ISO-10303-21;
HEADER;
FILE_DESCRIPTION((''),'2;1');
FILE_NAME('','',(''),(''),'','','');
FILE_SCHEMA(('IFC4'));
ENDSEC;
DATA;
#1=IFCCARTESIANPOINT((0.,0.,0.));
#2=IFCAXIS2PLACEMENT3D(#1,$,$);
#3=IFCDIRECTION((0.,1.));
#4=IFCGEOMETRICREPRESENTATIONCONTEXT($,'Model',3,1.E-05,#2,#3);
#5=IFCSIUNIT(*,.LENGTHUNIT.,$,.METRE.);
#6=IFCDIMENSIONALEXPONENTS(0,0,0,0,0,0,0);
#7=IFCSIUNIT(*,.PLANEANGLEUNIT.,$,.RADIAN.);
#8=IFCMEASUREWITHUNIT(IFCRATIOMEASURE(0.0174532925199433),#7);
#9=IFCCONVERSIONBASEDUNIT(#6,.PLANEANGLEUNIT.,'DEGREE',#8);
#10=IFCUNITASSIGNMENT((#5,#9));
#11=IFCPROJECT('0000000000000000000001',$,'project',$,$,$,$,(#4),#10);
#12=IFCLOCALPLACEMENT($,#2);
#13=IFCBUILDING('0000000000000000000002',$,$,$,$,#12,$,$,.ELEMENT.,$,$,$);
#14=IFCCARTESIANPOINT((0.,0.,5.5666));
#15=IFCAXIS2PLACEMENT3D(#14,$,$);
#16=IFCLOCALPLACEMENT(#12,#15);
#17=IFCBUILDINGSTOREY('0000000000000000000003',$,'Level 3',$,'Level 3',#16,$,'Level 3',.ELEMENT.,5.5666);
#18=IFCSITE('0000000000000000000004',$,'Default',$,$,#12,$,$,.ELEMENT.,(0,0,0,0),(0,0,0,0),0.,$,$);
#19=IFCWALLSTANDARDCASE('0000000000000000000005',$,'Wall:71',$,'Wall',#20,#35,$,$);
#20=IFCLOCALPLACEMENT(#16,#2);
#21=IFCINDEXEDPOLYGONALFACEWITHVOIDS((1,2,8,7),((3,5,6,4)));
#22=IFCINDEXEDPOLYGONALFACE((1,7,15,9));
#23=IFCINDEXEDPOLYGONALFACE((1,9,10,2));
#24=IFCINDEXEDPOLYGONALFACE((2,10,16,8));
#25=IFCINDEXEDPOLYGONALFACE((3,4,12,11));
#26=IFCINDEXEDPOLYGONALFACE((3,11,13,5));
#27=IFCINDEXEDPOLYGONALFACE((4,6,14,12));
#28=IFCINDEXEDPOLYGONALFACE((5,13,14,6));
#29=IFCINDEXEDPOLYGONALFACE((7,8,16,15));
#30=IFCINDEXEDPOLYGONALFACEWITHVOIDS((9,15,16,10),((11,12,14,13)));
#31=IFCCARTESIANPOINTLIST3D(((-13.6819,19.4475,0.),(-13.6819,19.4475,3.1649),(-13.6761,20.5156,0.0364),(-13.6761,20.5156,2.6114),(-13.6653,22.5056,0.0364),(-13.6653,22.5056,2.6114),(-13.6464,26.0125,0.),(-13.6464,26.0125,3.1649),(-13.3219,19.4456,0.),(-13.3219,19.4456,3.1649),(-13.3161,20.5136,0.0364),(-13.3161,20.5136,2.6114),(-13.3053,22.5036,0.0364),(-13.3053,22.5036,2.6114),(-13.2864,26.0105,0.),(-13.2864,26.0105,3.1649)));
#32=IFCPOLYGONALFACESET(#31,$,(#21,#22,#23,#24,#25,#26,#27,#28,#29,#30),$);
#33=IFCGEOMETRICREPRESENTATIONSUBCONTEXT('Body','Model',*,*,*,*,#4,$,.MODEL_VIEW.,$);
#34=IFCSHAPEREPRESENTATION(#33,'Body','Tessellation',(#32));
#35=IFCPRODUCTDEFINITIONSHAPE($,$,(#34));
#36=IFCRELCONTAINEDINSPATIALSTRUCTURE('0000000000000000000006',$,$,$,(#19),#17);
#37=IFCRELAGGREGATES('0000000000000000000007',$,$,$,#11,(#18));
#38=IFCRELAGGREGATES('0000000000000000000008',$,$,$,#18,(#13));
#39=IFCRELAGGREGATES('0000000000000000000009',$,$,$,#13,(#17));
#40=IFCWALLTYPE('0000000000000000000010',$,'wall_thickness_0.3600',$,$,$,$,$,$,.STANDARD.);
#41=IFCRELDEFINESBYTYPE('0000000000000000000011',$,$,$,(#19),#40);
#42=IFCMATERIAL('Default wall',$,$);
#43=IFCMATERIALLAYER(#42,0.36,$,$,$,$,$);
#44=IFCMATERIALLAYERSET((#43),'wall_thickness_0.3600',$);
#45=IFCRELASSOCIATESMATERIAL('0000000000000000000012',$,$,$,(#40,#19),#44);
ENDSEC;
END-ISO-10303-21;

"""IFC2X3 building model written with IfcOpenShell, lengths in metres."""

from ifc_helpers import new_model, entity, si_unit, converted_unit, direction, frame, frame_2d, origin, place, context, subcontext, project, spatial, polyline, rectangle, outline, extrude, material, layer, layer_set, layer_usage, type_object, element, save


model = new_model("IFC2X3")

# Units and contexts
model_context = context("Model", 3, precision=1e-05, world=origin(), true_north=direction((0.0, 1.0)))
body_context = subcontext(model_context, "Body", "Model", "MODEL_VIEW")
ifc_project = project(units=[si_unit("LENGTHUNIT", "METRE"), converted_unit("PLANEANGLEUNIT", "DEGREE", entity("IfcRatioMeasure", 0.0174532925199433), si_unit("PLANEANGLEUNIT", "RADIAN"), dimensions=[0, 0, 0, 0, 0, 0, 0])], contexts=[model_context])

# Site, building, storey
placement_1 = place(None, origin())
site = spatial("IfcSite", under=ifc_project, at=placement_1, Name="Default", CompositionType="ELEMENT", RefLatitude=(0, 0, 0, 0), RefLongitude=(0, 0, 0, 0), RefElevation=0.0)
building = spatial("IfcBuilding", under=site, at=placement_1, CompositionType="ELEMENT")
storey_placement = place(placement_1, frame((0.0, 0.0, 5.5666)))
storey = spatial("IfcBuildingStorey", under=building, at=storey_placement, Name="Level 3", ObjectType="Level 3", LongName="Level 3", CompositionType="ELEMENT", Elevation=5.5666)

# Shared definitions
ifc_material_1 = material(Name="Default wall")

# Shared definitions
ifc_layer_1 = layer(ifc_material_1, 0.36)
ifc_layer_set_1 = layer_set([ifc_layer_1], Name="wall_thickness_0.3600")
ifc_layer_usage_1 = layer_usage(ifc_layer_set_1, "AXIS2", "POSITIVE", -0.18)
wall_type_1 = type_object("IfcWallType", Name="wall_thickness_0.3600", PredefinedType="STANDARD", material=ifc_layer_set_1)

# Wall, opening
wall_1_placement = place(storey_placement, frame((-13.4664, 26.0115, 0.0), z_axis=(0.0, 0.0, 1.0), x_axis=(-0.005406, -0.999985, 0.0)))
wall_1 = element("IfcWallStandardCase", 1, at=wall_1_placement, inside=storey, type_object=wall_type_1, material=ifc_layer_usage_1, Name="Wall:71", ObjectType="Wall", context=body_context, shape_type="SweptSolid", body=[
    extrude(outline(polyline([(6.565, -0.18), (6.565, 0.18), (0.0, 0.18), (0.0, -0.18), (6.565, -0.18)])), origin(), (0.0, 0.0, 1.0), 3.1649),
])
opening_1_placement = place(wall_1_placement, frame((3.507, -0.18, 0.0364)))
element("IfcOpeningElement", 2, at=opening_1_placement, cuts=wall_1, ObjectType="Opening", context=body_context, shape_type="SweptSolid", body=[
    extrude(rectangle(XDim=1.99, YDim=2.575, at=frame_2d((1.2875, 0.995), x_axis=(0.0, 1.0))), frame((0.0, 0.0, 0.0), z_axis=(0.0, 1.0, 0.0), x_axis=(0.0, 0.0, 1.0)), (0.0, 0.0, 1.0), 0.36),
])

save(model, "model.ifc")
